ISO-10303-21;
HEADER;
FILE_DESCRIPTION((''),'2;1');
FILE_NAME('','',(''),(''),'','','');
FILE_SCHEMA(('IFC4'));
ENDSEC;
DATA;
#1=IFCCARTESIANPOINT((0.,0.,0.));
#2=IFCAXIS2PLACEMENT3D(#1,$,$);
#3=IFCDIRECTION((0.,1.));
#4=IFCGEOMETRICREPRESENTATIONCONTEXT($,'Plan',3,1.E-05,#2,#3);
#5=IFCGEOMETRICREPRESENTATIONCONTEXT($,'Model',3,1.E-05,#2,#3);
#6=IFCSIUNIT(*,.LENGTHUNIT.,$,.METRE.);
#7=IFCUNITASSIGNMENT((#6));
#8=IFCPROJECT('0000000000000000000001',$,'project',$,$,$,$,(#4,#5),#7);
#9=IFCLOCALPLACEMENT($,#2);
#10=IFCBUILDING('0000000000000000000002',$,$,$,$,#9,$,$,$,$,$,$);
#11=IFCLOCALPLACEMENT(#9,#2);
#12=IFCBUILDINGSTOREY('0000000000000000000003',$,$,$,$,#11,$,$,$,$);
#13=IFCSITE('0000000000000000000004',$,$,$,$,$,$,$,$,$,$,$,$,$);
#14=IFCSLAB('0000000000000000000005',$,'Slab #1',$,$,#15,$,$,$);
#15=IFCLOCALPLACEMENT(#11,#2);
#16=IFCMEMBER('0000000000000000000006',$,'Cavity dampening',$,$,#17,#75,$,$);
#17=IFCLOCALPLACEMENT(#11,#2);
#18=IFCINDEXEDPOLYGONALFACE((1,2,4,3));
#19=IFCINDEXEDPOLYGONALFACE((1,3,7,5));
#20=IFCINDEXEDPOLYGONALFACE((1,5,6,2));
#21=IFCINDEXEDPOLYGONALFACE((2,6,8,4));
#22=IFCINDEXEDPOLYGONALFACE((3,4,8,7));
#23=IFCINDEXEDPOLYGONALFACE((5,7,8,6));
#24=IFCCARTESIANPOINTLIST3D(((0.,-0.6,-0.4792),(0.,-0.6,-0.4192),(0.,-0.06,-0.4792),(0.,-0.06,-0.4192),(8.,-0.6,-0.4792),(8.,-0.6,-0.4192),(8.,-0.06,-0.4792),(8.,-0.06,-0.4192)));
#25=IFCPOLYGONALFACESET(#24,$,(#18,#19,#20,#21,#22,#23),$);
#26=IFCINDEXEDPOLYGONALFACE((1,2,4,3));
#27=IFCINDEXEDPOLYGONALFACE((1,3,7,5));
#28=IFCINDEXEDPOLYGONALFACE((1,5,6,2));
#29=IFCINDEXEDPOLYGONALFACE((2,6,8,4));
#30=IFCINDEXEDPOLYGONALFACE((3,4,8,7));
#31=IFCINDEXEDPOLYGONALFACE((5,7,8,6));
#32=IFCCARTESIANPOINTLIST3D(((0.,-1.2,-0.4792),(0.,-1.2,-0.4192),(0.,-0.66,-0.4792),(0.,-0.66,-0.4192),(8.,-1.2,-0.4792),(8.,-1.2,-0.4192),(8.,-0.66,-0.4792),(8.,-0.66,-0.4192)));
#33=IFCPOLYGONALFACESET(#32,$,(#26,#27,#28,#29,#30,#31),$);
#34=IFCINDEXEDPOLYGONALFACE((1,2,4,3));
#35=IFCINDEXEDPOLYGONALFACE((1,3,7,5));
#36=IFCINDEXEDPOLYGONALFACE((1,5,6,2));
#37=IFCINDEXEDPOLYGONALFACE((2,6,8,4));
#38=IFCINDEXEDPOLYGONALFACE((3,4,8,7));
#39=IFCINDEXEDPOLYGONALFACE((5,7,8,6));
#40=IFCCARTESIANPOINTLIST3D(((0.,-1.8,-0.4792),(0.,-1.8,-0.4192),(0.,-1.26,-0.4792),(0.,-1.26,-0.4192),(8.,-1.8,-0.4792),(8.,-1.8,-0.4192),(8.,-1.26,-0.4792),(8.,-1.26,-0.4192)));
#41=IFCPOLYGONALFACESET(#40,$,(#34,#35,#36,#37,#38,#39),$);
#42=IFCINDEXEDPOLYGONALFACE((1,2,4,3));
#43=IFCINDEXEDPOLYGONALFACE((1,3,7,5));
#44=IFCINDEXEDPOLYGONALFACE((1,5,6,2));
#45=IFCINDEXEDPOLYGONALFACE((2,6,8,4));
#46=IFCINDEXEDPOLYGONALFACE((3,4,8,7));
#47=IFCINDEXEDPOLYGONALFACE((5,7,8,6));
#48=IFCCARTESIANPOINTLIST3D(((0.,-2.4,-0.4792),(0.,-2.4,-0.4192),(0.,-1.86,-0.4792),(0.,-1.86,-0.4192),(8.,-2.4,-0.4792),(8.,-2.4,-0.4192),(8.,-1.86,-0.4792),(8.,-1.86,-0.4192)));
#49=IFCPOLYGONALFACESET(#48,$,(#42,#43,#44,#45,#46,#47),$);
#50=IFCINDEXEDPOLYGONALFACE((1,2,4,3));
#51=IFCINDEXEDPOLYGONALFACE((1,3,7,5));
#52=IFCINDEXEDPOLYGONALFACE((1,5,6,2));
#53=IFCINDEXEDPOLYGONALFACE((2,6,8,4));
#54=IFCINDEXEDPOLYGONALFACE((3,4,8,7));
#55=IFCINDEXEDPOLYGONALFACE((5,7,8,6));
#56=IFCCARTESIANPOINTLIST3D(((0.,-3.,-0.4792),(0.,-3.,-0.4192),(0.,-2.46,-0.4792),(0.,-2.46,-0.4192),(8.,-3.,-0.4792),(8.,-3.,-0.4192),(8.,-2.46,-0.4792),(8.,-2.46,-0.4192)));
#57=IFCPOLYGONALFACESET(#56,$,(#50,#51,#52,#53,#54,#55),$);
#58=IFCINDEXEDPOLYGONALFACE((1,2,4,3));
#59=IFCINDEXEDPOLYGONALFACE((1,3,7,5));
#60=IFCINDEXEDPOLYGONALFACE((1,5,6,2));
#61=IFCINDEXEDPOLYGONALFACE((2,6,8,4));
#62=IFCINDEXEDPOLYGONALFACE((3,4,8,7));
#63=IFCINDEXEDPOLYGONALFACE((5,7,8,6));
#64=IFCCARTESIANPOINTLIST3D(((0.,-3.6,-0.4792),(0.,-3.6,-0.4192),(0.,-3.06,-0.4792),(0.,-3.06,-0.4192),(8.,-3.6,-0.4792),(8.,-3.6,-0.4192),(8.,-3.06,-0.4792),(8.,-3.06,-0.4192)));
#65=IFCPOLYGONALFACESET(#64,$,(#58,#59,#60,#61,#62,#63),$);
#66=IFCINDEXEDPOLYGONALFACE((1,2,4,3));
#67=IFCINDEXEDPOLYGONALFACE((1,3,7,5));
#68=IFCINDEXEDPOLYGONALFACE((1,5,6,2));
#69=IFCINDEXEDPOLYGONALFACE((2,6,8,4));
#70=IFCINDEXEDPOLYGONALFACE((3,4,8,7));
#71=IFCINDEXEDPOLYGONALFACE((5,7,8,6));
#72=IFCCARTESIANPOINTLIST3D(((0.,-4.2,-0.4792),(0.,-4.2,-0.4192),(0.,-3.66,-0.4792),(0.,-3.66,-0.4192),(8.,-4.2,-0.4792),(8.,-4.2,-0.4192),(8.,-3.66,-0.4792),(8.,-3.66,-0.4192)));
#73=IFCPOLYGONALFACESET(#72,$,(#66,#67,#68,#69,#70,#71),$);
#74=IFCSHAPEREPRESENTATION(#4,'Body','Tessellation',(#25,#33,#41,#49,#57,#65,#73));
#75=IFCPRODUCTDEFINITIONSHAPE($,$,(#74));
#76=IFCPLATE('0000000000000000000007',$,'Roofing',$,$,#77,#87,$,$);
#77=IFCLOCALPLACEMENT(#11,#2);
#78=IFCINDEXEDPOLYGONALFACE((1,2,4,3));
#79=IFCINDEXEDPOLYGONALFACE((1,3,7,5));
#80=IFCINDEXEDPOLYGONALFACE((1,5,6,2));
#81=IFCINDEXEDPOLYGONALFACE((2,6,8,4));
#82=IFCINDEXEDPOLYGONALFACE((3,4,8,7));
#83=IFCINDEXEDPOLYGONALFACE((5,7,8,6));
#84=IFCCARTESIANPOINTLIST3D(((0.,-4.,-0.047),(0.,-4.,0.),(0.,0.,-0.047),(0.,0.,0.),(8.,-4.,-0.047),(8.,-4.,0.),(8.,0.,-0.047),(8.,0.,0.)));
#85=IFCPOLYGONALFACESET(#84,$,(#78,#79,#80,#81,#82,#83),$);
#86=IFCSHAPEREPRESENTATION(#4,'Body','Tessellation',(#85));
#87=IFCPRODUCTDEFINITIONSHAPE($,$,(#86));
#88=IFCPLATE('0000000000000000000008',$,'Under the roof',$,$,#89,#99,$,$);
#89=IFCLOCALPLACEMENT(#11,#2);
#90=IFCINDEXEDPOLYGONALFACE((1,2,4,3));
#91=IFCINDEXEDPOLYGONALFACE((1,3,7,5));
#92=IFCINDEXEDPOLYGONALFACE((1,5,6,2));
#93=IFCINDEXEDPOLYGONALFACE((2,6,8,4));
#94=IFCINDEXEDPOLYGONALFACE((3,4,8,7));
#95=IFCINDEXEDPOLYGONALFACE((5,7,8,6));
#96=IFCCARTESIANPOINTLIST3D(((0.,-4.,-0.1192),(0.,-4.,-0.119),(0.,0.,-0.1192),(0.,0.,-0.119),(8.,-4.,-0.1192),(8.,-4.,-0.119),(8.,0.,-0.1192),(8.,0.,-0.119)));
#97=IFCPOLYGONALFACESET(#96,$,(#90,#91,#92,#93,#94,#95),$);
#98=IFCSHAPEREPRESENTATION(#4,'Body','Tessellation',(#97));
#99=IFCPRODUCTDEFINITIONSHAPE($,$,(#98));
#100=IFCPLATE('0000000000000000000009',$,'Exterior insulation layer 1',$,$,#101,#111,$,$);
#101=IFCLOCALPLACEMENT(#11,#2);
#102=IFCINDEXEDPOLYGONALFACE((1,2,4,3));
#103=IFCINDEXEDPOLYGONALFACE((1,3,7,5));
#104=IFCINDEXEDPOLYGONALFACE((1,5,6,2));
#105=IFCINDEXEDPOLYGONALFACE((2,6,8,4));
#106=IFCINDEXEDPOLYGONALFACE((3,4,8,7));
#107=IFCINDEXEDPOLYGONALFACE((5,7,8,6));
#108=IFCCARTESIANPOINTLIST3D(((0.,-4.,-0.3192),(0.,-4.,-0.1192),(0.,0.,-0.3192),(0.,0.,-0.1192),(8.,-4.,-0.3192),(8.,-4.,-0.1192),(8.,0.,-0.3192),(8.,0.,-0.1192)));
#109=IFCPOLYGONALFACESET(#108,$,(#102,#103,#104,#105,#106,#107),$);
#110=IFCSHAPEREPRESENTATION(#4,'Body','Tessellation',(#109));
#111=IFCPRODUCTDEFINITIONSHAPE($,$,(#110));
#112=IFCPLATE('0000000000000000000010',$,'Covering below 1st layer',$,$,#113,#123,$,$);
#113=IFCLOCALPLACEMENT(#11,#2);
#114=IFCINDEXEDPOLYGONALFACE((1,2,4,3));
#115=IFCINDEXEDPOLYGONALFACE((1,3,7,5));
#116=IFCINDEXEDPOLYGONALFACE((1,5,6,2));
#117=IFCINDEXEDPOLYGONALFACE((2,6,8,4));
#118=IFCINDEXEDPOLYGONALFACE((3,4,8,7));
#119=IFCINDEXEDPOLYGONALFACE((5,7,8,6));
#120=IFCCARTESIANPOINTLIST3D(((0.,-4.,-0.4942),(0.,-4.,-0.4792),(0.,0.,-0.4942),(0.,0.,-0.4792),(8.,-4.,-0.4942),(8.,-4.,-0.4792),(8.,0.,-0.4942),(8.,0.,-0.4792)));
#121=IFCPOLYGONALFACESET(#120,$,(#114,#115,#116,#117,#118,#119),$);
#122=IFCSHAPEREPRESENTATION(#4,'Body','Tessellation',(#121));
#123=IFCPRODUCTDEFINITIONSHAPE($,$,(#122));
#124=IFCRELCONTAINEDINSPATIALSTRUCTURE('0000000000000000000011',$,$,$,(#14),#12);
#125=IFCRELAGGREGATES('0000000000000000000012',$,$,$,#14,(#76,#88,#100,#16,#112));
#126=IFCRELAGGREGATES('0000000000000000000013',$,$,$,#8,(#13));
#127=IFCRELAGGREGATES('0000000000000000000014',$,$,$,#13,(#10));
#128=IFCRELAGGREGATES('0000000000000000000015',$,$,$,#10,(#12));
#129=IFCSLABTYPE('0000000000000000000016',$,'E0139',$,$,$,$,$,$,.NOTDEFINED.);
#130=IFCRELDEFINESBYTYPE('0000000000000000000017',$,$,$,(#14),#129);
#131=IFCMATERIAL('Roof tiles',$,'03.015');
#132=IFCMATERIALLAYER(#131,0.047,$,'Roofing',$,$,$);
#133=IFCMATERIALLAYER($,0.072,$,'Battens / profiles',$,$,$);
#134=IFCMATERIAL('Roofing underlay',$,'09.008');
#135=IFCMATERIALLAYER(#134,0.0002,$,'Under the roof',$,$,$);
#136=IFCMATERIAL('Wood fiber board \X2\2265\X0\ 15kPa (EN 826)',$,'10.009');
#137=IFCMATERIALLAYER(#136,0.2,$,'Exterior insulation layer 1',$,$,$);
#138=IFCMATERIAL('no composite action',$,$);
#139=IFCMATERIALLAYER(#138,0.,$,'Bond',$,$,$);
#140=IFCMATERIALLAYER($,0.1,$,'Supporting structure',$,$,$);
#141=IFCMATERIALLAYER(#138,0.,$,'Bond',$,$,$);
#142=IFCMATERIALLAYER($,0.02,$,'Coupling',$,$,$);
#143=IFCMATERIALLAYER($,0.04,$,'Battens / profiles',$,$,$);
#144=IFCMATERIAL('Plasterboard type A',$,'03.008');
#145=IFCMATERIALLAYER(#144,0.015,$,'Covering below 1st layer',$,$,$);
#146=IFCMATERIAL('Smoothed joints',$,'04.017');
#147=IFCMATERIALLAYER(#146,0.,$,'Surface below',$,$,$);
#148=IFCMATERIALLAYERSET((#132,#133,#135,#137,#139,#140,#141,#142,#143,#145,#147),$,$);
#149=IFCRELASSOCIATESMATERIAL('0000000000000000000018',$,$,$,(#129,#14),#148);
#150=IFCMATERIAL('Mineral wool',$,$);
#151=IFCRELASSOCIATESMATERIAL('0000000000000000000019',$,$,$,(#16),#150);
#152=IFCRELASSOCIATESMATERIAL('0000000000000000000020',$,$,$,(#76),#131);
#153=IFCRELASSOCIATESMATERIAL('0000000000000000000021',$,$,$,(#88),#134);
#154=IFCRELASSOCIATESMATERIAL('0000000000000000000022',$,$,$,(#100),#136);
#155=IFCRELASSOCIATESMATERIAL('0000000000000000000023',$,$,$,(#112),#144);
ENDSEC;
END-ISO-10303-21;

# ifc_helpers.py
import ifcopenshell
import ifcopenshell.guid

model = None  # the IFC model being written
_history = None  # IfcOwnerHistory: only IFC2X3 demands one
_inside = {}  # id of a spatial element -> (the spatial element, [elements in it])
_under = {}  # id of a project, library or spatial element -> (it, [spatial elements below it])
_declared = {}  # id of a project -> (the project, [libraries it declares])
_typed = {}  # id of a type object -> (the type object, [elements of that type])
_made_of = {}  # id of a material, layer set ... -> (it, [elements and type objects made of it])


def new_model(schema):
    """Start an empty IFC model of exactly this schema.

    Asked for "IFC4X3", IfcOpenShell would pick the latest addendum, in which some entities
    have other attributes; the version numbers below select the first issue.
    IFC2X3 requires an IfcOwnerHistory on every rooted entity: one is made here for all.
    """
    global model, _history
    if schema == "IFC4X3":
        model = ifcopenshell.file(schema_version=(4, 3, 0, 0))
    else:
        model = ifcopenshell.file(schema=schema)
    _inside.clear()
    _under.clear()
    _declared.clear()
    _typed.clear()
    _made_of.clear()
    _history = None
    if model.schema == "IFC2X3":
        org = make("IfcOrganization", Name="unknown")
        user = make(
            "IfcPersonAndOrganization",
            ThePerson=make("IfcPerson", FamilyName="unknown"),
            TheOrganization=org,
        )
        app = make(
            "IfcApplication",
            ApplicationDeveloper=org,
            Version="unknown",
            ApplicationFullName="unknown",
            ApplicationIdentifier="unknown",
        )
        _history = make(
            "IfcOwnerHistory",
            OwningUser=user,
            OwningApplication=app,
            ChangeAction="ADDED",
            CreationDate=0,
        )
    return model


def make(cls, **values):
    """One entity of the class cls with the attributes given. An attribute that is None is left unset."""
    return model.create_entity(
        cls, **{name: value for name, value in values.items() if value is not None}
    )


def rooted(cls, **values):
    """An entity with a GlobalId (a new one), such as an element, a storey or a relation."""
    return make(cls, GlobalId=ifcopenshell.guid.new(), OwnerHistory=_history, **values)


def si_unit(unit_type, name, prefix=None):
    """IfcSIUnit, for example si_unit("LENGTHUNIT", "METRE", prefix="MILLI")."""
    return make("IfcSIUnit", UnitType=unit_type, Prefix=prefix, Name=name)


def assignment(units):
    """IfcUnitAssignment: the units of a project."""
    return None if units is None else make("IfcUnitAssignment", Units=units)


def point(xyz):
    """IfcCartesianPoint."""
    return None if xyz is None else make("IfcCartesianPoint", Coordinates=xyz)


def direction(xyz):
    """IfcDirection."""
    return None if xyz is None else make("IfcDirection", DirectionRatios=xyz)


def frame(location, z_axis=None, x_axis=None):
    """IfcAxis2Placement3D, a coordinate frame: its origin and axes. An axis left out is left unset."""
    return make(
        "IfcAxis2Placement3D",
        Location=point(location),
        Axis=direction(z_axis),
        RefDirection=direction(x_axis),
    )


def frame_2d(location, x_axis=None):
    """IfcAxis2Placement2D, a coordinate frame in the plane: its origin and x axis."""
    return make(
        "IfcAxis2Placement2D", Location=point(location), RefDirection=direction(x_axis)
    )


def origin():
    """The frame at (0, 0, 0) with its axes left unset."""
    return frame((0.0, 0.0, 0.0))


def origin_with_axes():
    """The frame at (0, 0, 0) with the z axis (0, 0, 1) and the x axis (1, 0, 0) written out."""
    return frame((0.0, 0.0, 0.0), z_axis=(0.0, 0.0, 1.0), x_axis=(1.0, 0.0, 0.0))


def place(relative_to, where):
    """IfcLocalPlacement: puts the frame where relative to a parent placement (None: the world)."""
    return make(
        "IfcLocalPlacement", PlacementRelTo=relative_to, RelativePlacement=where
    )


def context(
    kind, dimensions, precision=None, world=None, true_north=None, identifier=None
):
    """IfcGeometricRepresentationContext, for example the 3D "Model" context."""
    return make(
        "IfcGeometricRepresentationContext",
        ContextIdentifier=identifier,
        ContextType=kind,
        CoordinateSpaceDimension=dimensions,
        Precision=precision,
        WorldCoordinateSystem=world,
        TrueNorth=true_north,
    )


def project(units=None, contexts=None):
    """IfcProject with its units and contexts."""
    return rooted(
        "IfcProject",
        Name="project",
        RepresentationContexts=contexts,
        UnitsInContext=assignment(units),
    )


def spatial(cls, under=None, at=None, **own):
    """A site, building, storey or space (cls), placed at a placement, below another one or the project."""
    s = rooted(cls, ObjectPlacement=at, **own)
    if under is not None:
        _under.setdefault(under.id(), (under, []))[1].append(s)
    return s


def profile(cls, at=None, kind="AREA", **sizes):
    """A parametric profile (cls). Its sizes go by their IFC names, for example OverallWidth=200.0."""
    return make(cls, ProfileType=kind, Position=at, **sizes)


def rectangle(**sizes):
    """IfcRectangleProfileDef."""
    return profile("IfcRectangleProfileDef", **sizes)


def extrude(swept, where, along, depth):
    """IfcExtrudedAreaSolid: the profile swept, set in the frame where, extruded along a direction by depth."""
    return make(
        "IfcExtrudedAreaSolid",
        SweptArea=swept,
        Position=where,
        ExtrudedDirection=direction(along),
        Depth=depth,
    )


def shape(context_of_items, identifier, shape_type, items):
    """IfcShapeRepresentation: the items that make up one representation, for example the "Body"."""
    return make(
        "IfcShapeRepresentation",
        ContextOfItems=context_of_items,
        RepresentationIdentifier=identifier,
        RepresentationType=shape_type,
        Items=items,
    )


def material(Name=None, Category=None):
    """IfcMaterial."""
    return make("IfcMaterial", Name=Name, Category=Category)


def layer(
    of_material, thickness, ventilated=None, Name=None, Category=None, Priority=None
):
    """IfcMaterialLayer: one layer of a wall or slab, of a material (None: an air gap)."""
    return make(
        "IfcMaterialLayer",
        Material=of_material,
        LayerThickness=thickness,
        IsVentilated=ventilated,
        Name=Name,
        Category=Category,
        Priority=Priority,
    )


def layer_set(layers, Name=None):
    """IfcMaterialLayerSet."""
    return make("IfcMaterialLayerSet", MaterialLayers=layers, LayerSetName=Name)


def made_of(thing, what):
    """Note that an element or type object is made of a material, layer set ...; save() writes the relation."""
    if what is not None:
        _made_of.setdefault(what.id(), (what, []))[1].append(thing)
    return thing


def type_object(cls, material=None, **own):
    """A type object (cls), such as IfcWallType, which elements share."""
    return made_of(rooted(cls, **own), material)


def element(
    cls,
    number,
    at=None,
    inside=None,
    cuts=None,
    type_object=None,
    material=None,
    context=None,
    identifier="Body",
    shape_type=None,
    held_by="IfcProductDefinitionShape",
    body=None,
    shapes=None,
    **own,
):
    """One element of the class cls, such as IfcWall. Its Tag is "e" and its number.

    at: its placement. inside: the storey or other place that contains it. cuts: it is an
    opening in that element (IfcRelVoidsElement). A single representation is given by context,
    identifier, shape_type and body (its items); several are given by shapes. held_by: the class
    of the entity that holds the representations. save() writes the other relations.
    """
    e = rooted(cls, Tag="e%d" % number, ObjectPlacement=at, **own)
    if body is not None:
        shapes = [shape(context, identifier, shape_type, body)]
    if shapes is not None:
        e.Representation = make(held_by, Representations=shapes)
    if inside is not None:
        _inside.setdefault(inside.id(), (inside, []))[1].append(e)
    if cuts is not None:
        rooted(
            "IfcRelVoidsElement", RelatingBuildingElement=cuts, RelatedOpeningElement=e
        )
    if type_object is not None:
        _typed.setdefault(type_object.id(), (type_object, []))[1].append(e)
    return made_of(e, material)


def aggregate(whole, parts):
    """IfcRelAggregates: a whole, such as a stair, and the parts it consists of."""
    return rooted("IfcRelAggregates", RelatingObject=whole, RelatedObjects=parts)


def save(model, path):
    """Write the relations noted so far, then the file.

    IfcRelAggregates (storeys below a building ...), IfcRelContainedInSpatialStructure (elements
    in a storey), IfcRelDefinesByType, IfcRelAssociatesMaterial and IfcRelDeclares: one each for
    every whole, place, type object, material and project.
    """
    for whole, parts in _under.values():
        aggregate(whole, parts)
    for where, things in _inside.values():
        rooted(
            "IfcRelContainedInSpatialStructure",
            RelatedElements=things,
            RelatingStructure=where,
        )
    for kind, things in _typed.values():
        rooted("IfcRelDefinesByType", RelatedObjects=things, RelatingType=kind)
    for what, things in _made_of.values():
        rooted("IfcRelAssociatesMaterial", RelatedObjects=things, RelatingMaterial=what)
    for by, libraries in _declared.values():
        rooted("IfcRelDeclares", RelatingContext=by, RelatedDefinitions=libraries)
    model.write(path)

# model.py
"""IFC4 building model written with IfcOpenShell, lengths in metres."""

from ifc_helpers import new_model, si_unit, direction, frame, frame_2d, origin, origin_with_axes, place, context, project, spatial, rectangle, extrude, material, layer, layer_set, type_object, element, aggregate, save


model = new_model("IFC4")

# Units and contexts
plan_context = context("Plan", 3, precision=1e-05, world=origin(), true_north=direction((0.0, 1.0)))
model_context = context("Model", 3, precision=1e-05, world=origin(), true_north=direction((0.0, 1.0)))
ifc_project = project(units=[si_unit("LENGTHUNIT", "METRE")], contexts=[plan_context, model_context])

# Site, building, storey
site = spatial("IfcSite", under=ifc_project)
building_placement = place(None, origin())
building = spatial("IfcBuilding", under=site, at=building_placement)
storey_placement = place(building_placement, origin())
storey = spatial("IfcBuildingStorey", under=building, at=storey_placement)

# Slab, member, plates
ifc_material_1 = material(Name="Roof tiles", Category="03.015")
ifc_layer_1 = layer(ifc_material_1, 0.047, Name="Roofing")
ifc_layer_2 = layer(None, 0.072, Name="Battens / profiles")
ifc_material_2 = material(Name="Roofing underlay", Category="09.008")
ifc_layer_3 = layer(ifc_material_2, 0.0002, Name="Under the roof")
ifc_material_3 = material(Name="Wood fiber board ≥ 15kPa (EN 826)", Category="10.009")
ifc_layer_4 = layer(ifc_material_3, 0.2, Name="Exterior insulation layer 1")
ifc_material_4 = material(Name="no composite action")
ifc_layer_5 = layer(ifc_material_4, 0.0, Name="Bond")
ifc_layer_6 = layer(None, 0.1, Name="Supporting structure")
ifc_layer_7 = layer(ifc_material_4, 0.0, Name="Bond")
ifc_layer_8 = layer(None, 0.02, Name="Coupling")
ifc_layer_9 = layer(None, 0.04, Name="Battens / profiles")
ifc_material_5 = material(Name="Plasterboard type A", Category="03.008")
ifc_layer_10 = layer(ifc_material_5, 0.015, Name="Covering below 1st layer")
ifc_material_6 = material(Name="Smoothed joints", Category="04.017")
ifc_layer_11 = layer(ifc_material_6, 0.0, Name="Surface below")
ifc_layer_set = layer_set([ifc_layer_1, ifc_layer_2, ifc_layer_3, ifc_layer_4, ifc_layer_5, ifc_layer_6, ifc_layer_7, ifc_layer_8, ifc_layer_9, ifc_layer_10, ifc_layer_11])
slab_type = type_object("IfcSlabType", Name="E0139", PredefinedType="NOTDEFINED", material=ifc_layer_set)
slab_placement = place(None, frame((0.0, 0.0, 0.0), z_axis=(0.0, 0.0, -1.0), x_axis=(1.0, 0.0, 0.0)))
slab = element("IfcSlab", 1, at=slab_placement, inside=storey, type_object=slab_type, material=ifc_layer_set, Name="Slab #1")
ifc_material_7 = material(Name="Mineral wool")
member_1_placement = place(slab_placement, origin())
member_1 = element("IfcMember", 2, at=member_1_placement, material=ifc_material_7, Name="Cavity dampening", context=plan_context, shape_type="SweptSolid", body=[
    extrude(rectangle(XDim=0.54, YDim=0.06, at=frame_2d((0.27, 0.03), x_axis=(1.0, 0.0))), frame((0.0, 0.06, 0.4192), z_axis=(1.0, 0.0, 0.0), x_axis=(0.0, 1.0, 0.0)), (0.0, 0.0, 1.0), 8.0),
    extrude(rectangle(XDim=0.54, YDim=0.06, at=frame_2d((0.27, 0.03), x_axis=(1.0, 0.0))), frame((0.0, 0.66, 0.4192), z_axis=(1.0, 0.0, 0.0), x_axis=(0.0, 1.0, 0.0)), (0.0, 0.0, 1.0), 8.0),
    extrude(rectangle(XDim=0.54, YDim=0.06, at=frame_2d((0.27, 0.03), x_axis=(1.0, 0.0))), frame((0.0, 1.26, 0.4192), z_axis=(1.0, 0.0, 0.0), x_axis=(0.0, 1.0, 0.0)), (0.0, 0.0, 1.0), 8.0),
    extrude(rectangle(XDim=0.54, YDim=0.06, at=frame_2d((0.27, 0.03), x_axis=(1.0, 0.0))), frame((0.0, 1.86, 0.4192), z_axis=(1.0, 0.0, 0.0), x_axis=(0.0, 1.0, 0.0)), (0.0, 0.0, 1.0), 8.0),
    extrude(rectangle(XDim=0.54, YDim=0.06, at=frame_2d((0.27, 0.03), x_axis=(1.0, 0.0))), frame((0.0, 2.46, 0.4192), z_axis=(1.0, 0.0, 0.0), x_axis=(0.0, 1.0, 0.0)), (0.0, 0.0, 1.0), 8.0),
    extrude(rectangle(XDim=0.54, YDim=0.06, at=frame_2d((0.27, 0.03), x_axis=(1.0, 0.0))), frame((0.0, 3.06, 0.4192), z_axis=(1.0, 0.0, 0.0), x_axis=(0.0, 1.0, 0.0)), (0.0, 0.0, 1.0), 8.0),
    extrude(rectangle(XDim=0.54, YDim=0.06, at=frame_2d((0.27, 0.03), x_axis=(1.0, 0.0))), frame((0.0, 3.66, 0.4192), z_axis=(1.0, 0.0, 0.0), x_axis=(0.0, 1.0, 0.0)), (0.0, 0.0, 1.0), 8.0),
])
plate_1_placement = place(slab_placement, origin())
plate_1 = element("IfcPlate", 3, at=plate_1_placement, material=ifc_material_1, Name="Roofing", context=plan_context, shape_type="SweptSolid", body=[
    extrude(rectangle(XDim=8.0, YDim=4.0, at=frame_2d((4.0, 2.0), x_axis=(1.0, 0.0))), origin_with_axes(), (0.0, 0.0, 1.0), 0.047),
])
plate_2_placement = place(slab_placement, origin())
plate_2 = element("IfcPlate", 4, at=plate_2_placement, material=ifc_material_2, Name="Under the roof", context=plan_context, shape_type="SweptSolid", body=[
    extrude(rectangle(XDim=8.0, YDim=4.0, at=frame_2d((4.0, 2.0), x_axis=(1.0, 0.0))), frame((0.0, 0.0, 0.119), z_axis=(0.0, 0.0, 1.0), x_axis=(1.0, 0.0, 0.0)), (0.0, 0.0, 1.0), 0.0002),
])
plate_3_placement = place(slab_placement, origin())
plate_3 = element("IfcPlate", 5, at=plate_3_placement, material=ifc_material_3, Name="Exterior insulation layer 1", context=plan_context, shape_type="SweptSolid", body=[
    extrude(rectangle(XDim=8.0, YDim=4.0, at=frame_2d((4.0, 2.0), x_axis=(1.0, 0.0))), frame((0.0, 0.0, 0.1192), z_axis=(0.0, 0.0, 1.0), x_axis=(1.0, 0.0, 0.0)), (0.0, 0.0, 1.0), 0.2),
])
plate_4_placement = place(slab_placement, origin())
plate_4 = element("IfcPlate", 6, at=plate_4_placement, material=ifc_material_5, Name="Covering below 1st layer", context=plan_context, shape_type="SweptSolid", body=[
    extrude(rectangle(XDim=8.0, YDim=4.0, at=frame_2d((4.0, 2.0), x_axis=(1.0, 0.0))), frame((0.0, 0.0, 0.4792), z_axis=(0.0, 0.0, 1.0), x_axis=(1.0, 0.0, 0.0)), (0.0, 0.0, 1.0), 0.015),
])
aggregate(slab, [plate_1, plate_2, plate_3, member_1, plate_4])

save(model, "model.ifc")
